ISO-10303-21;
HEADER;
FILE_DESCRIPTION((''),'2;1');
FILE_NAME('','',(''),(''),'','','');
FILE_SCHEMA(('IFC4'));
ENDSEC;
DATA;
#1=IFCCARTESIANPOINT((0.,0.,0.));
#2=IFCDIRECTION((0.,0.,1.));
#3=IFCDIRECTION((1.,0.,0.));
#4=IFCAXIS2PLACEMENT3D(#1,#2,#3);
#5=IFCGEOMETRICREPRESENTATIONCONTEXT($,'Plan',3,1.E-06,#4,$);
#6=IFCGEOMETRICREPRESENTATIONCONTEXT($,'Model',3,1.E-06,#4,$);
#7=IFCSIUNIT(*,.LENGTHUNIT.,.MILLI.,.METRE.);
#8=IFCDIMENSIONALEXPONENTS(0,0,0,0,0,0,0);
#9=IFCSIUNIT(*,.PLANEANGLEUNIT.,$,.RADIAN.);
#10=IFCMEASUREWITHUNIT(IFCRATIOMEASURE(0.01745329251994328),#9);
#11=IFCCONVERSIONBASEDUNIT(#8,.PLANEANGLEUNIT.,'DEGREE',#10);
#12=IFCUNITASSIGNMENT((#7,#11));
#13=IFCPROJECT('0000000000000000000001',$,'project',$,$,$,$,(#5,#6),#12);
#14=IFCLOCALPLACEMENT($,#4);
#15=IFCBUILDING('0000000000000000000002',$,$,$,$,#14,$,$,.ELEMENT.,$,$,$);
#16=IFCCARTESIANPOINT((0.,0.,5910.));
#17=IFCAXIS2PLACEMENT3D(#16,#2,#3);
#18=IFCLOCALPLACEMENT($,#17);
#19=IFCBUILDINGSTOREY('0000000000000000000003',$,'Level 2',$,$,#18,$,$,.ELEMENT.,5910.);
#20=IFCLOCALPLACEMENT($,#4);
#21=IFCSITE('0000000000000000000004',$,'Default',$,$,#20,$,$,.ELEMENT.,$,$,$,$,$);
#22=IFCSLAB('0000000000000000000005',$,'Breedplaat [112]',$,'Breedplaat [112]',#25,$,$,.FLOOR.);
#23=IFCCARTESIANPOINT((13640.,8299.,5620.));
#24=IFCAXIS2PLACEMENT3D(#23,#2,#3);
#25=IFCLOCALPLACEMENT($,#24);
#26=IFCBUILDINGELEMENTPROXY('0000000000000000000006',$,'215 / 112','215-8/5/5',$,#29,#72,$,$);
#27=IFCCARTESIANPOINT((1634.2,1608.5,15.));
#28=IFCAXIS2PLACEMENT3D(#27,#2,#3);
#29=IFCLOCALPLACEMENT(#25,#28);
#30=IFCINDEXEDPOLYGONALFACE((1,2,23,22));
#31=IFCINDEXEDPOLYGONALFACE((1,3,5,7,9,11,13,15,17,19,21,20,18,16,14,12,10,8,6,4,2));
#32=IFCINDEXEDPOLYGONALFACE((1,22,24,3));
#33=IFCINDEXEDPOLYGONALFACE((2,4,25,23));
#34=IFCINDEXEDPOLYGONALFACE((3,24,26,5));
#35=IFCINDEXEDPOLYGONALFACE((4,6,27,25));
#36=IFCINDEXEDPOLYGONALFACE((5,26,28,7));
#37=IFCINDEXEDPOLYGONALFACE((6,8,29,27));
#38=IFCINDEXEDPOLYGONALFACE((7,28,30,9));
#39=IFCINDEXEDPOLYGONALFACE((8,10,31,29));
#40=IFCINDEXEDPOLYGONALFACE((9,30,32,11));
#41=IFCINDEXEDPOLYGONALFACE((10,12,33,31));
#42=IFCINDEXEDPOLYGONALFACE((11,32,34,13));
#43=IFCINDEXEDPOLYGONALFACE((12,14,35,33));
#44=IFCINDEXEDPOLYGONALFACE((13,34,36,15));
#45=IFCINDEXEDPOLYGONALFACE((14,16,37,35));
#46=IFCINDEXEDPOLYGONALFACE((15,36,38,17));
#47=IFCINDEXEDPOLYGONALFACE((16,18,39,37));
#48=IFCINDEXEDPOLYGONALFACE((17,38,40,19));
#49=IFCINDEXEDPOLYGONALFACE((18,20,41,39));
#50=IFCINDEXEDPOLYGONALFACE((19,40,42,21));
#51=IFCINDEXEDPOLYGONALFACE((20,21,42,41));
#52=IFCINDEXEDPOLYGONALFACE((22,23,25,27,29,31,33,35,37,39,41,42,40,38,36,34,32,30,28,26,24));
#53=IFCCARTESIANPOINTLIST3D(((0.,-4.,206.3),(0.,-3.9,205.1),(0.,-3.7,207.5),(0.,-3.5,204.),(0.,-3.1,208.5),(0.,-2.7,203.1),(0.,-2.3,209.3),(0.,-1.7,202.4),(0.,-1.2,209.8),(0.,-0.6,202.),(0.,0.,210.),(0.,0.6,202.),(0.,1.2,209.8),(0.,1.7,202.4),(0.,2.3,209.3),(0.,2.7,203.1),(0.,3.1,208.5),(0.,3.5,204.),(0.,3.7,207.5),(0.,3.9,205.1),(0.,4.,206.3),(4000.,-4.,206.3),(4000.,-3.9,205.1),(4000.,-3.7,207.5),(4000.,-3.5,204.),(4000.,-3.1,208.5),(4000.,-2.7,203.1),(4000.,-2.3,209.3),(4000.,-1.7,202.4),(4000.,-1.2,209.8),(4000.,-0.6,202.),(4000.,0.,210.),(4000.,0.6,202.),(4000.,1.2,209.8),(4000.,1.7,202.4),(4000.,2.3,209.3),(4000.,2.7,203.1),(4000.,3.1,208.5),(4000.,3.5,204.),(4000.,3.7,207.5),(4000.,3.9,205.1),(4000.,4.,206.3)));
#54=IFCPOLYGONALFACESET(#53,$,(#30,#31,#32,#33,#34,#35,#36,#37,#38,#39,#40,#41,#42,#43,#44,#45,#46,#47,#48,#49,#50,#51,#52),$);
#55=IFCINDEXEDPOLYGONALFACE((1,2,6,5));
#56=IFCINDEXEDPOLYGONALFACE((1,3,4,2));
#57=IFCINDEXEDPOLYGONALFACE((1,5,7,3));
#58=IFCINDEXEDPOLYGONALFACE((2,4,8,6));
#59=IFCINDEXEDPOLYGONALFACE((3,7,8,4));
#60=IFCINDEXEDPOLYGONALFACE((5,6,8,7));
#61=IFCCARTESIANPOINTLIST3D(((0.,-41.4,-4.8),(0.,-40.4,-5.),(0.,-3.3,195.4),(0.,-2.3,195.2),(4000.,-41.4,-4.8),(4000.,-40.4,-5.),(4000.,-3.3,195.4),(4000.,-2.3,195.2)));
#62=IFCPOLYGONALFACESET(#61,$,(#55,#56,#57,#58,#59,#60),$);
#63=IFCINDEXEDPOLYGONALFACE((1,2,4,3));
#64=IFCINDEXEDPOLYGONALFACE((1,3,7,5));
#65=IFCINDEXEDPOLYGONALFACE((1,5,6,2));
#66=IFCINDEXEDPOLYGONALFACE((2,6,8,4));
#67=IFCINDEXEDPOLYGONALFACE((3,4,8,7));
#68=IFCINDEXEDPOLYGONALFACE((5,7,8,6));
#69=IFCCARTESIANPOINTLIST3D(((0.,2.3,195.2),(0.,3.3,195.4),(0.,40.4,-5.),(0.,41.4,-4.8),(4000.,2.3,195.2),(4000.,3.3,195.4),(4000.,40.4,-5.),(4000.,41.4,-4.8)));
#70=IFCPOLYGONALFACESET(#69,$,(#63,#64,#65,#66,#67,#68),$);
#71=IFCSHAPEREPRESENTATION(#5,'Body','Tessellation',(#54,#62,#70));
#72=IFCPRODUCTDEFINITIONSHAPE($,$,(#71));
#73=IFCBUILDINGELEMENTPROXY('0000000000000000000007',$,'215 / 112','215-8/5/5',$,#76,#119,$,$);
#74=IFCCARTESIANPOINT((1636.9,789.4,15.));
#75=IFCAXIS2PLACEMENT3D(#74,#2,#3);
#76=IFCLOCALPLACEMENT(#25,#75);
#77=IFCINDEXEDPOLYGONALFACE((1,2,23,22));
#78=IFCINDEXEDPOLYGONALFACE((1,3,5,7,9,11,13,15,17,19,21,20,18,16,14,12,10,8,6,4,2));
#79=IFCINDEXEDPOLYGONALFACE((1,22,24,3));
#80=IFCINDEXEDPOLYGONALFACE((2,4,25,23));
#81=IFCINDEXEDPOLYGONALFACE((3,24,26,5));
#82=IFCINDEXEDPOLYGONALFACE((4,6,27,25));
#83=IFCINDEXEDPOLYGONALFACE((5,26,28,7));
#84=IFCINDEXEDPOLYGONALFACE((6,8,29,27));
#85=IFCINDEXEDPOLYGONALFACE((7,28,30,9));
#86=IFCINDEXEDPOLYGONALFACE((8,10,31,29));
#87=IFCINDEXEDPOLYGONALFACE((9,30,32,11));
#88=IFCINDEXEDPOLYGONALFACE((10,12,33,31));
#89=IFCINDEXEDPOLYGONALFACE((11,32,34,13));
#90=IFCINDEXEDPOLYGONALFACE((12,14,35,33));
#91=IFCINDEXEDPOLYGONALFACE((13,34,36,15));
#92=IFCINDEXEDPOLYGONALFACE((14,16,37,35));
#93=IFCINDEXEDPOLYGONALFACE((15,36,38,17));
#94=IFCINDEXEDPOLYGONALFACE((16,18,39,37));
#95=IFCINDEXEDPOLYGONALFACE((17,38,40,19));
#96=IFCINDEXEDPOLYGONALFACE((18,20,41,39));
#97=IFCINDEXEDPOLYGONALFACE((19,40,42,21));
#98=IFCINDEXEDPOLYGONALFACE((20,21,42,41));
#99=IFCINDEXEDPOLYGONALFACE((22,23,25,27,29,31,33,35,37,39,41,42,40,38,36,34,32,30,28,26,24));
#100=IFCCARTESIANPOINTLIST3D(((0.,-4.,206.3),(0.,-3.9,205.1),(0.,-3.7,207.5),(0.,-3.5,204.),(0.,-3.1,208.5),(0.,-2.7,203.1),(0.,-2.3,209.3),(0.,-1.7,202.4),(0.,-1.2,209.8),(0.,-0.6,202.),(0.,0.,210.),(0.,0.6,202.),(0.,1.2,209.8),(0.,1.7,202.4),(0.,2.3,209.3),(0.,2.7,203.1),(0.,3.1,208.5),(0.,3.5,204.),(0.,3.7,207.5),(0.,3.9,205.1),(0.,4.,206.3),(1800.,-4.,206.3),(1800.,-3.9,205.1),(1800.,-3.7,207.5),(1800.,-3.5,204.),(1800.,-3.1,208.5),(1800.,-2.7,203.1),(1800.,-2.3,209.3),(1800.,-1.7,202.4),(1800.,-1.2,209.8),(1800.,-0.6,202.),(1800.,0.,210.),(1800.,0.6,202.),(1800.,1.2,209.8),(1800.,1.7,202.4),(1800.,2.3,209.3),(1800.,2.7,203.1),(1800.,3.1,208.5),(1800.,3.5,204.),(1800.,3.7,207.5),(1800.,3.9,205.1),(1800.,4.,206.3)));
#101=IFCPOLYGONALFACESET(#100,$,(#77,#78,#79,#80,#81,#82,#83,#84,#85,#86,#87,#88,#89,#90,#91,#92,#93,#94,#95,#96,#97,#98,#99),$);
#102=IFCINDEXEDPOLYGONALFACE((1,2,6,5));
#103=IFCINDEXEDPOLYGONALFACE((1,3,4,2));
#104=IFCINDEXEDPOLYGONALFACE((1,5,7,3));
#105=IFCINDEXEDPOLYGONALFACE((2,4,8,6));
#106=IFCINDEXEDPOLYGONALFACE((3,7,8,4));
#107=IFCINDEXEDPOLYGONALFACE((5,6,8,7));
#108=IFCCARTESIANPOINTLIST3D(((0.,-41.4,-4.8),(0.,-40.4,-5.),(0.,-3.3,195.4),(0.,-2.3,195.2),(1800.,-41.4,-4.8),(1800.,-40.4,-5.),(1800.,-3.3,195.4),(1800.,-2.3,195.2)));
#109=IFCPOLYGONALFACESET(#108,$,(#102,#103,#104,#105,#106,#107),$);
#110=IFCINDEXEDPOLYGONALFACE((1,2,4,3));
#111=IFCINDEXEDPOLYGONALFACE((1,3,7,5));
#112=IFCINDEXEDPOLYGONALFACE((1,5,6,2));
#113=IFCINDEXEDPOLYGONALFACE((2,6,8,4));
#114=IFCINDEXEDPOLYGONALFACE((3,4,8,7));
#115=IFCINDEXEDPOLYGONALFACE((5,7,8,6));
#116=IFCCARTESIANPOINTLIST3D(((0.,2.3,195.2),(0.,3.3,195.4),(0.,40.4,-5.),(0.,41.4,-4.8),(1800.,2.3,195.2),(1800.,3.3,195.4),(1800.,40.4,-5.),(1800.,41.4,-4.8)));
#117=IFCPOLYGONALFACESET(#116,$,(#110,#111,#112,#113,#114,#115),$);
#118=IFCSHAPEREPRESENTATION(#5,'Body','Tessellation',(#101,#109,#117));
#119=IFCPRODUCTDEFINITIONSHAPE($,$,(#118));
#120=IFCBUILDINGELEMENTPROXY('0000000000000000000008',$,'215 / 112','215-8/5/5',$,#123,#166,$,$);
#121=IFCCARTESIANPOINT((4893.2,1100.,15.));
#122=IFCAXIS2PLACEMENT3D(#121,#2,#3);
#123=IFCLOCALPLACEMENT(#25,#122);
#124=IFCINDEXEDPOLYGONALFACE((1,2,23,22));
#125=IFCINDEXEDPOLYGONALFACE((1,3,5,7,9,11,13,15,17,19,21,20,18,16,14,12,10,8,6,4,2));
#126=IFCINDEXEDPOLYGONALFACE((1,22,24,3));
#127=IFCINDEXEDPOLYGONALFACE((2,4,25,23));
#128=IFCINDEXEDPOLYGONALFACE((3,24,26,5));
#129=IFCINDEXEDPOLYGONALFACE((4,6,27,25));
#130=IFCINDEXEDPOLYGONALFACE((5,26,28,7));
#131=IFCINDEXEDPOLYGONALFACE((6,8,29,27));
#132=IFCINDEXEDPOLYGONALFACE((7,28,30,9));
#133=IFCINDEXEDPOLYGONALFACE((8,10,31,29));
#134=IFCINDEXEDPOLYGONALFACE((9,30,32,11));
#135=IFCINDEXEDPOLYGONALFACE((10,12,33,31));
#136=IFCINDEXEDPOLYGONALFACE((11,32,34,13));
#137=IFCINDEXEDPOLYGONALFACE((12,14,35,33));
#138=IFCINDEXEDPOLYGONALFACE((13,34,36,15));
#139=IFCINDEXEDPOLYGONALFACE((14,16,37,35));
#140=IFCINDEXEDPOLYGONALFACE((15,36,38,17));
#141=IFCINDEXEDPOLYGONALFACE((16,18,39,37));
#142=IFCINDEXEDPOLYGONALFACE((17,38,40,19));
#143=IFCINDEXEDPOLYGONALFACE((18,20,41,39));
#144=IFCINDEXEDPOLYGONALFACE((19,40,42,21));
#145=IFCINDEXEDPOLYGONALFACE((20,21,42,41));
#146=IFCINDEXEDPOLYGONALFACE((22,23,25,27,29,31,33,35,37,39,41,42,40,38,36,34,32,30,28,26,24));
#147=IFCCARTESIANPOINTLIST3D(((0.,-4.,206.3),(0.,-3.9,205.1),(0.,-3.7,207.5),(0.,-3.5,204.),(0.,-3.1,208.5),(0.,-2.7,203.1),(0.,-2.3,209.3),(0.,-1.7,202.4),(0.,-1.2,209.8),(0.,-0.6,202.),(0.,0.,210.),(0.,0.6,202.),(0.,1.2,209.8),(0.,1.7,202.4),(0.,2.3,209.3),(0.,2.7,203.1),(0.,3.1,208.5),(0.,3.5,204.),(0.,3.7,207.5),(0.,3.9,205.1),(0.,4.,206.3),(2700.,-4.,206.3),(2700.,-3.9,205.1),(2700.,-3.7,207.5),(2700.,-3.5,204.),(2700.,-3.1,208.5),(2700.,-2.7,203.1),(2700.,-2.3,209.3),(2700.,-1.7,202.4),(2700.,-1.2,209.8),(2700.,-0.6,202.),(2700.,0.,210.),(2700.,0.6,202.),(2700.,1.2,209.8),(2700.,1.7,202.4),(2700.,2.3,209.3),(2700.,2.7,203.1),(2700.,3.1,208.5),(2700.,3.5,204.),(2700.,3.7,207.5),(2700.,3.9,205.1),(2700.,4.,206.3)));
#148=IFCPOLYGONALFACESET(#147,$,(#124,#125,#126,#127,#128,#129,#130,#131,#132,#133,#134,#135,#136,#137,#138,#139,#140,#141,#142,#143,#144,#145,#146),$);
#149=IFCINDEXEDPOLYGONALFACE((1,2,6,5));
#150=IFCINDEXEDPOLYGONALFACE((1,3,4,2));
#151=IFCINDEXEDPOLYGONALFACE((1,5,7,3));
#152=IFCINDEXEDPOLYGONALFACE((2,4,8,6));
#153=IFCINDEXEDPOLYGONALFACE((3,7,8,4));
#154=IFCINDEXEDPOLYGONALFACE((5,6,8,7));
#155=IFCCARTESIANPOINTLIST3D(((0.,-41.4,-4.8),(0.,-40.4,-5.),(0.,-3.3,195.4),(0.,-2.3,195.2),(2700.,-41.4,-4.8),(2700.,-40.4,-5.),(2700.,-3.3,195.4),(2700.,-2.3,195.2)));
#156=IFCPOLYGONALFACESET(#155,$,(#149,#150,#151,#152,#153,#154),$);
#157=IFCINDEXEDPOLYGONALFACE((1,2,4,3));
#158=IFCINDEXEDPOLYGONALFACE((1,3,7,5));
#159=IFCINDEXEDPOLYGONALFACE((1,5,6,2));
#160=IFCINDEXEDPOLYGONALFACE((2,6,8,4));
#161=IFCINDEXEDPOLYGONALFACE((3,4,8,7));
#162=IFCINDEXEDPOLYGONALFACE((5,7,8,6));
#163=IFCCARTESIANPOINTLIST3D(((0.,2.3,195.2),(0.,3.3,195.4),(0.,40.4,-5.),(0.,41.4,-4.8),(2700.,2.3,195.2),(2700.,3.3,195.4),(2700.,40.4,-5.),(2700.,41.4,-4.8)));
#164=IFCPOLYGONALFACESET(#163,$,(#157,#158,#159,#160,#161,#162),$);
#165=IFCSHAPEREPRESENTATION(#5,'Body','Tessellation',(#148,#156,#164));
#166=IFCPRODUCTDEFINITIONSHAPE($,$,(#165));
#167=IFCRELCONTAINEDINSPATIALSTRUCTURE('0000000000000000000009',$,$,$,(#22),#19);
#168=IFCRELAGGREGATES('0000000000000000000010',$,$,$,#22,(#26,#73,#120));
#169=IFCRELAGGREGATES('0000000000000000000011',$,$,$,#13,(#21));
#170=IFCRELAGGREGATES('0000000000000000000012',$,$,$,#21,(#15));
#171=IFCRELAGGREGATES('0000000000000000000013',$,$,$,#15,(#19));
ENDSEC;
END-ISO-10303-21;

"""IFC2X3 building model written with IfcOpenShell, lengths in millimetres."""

from ifc_helpers import new_model, entity, si_unit, converted_unit, frame, origin_with_axes, origin_2d_with_axis, place, context, project, spatial, rectangle, circle, extrude, element, aggregate, save


model = new_model("IFC2X3")

# Units and contexts
plan_context = context("Plan", 3, precision=1e-06, world=origin_with_axes())
model_context = context("Model", 3, precision=1e-06, world=origin_with_axes())
ifc_project = project(units=[si_unit("LENGTHUNIT", "METRE", prefix="MILLI"), converted_unit("PLANEANGLEUNIT", "DEGREE", entity("IfcRatioMeasure", 0.01745329251994328), si_unit("PLANEANGLEUNIT", "RADIAN"), dimensions=[0, 0, 0, 0, 0, 0, 0])], contexts=[plan_context, model_context])

# Site, building, storey
site_placement = place(None, origin_with_axes())
site = spatial("IfcSite", under=ifc_project, at=site_placement, Name="Default", CompositionType="ELEMENT")
building_placement = place(None, origin_with_axes())
building = spatial("IfcBuilding", under=site, at=building_placement, CompositionType="ELEMENT")
storey_placement = place(None, frame((0.0, 0.0, 5910.0), z_axis=(0.0, 0.0, 1.0), x_axis=(1.0, 0.0, 0.0)))
storey = spatial("IfcBuildingStorey", under=building, at=storey_placement, Name="Level 2", CompositionType="ELEMENT", Elevation=5910.0)

# Slab, building element proxies
slab_1_placement = place(None, frame((13640.0, 8299.0, 5620.0), z_axis=(0.0, 0.0, 1.0), x_axis=(1.0, 0.0, 0.0)))
slab_1 = element("IfcSlab", 1, at=slab_1_placement, inside=storey, Name="Breedplaat [112]", ObjectType="Breedplaat [112]", PredefinedType="FLOOR")
proxy_1_placement = place(slab_1_placement, frame((1634.2, 1608.5, 15.0), z_axis=(0.0, 0.0, 1.0), x_axis=(1.0, 0.0, 0.0)))
proxy_1 = element("IfcBuildingElementProxy", 2, at=proxy_1_placement, Name="215 / 112", Description="215-8/5/5", context=plan_context, shape_type="SweptSolid", body=[
    extrude(circle(Radius=4.0, at=origin_2d_with_axis()), frame((0.0, 0.0, 206.0), z_axis=(1.0, 0.0, 0.0), x_axis=(0.0, 0.0, 1.0)), (0.0, 0.0, 1.0), 4000.0),
    extrude(rectangle(XDim=203.8, YDim=1.0, at=origin_2d_with_axis()), frame((0.0, -21.9, 95.2), z_axis=(1.0, 0.0, 0.0), x_axis=(0.0, 0.187112, 0.982339)), (0.0, 0.0, 1.0), 4000.0),
    extrude(rectangle(XDim=203.8, YDim=1.0, at=origin_2d_with_axis()), frame((0.0, 21.9, 95.2), z_axis=(1.0, 0.0, 0.0), x_axis=(0.0, -0.187112, 0.982339)), (0.0, 0.0, 1.0), 4000.0),
])
proxy_2_placement = place(slab_1_placement, frame((1636.9, 789.4, 15.0), z_axis=(0.0, 0.0, 1.0), x_axis=(1.0, 0.0, 0.0)))
proxy_2 = element("IfcBuildingElementProxy", 3, at=proxy_2_placement, Name="215 / 112", Description="215-8/5/5", context=plan_context, shape_type="SweptSolid", body=[
    extrude(circle(Radius=4.0, at=origin_2d_with_axis()), frame((0.0, 0.0, 206.0), z_axis=(1.0, 0.0, 0.0), x_axis=(0.0, 0.0, 1.0)), (0.0, 0.0, 1.0), 1800.0),
    extrude(rectangle(XDim=203.8, YDim=1.0, at=origin_2d_with_axis()), frame((0.0, -21.9, 95.2), z_axis=(1.0, 0.0, 0.0), x_axis=(0.0, 0.187112, 0.982339)), (0.0, 0.0, 1.0), 1800.0),
    extrude(rectangle(XDim=203.8, YDim=1.0, at=origin_2d_with_axis()), frame((0.0, 21.9, 95.2), z_axis=(1.0, 0.0, 0.0), x_axis=(0.0, -0.187112, 0.982339)), (0.0, 0.0, 1.0), 1800.0),
])
proxy_3_placement = place(slab_1_placement, frame((4893.2, 1100.0, 15.0), z_axis=(0.0, 0.0, 1.0), x_axis=(1.0, 0.0, 0.0)))
proxy_3 = element("IfcBuildingElementProxy", 4, at=proxy_3_placement, Name="215 / 112", Description="215-8/5/5", context=plan_context, shape_type="SweptSolid", body=[
    extrude(circle(Radius=4.0, at=origin_2d_with_axis()), frame((0.0, 0.0, 206.0), z_axis=(1.0, 0.0, 0.0), x_axis=(0.0, 0.0, 1.0)), (0.0, 0.0, 1.0), 2700.0),
    extrude(rectangle(XDim=203.8, YDim=1.0, at=origin_2d_with_axis()), frame((0.0, -21.9, 95.2), z_axis=(1.0, 0.0, 0.0), x_axis=(0.0, 0.187112, 0.982339)), (0.0, 0.0, 1.0), 2700.0),
    extrude(rectangle(XDim=203.8, YDim=1.0, at=origin_2d_with_axis()), frame((0.0, 21.9, 95.2), z_axis=(1.0, 0.0, 0.0), x_axis=(0.0, -0.187112, 0.982339)), (0.0, 0.0, 1.0), 2700.0),
])
aggregate(slab_1, [proxy_1, proxy_2, proxy_3])

save(model, "model.ifc")
